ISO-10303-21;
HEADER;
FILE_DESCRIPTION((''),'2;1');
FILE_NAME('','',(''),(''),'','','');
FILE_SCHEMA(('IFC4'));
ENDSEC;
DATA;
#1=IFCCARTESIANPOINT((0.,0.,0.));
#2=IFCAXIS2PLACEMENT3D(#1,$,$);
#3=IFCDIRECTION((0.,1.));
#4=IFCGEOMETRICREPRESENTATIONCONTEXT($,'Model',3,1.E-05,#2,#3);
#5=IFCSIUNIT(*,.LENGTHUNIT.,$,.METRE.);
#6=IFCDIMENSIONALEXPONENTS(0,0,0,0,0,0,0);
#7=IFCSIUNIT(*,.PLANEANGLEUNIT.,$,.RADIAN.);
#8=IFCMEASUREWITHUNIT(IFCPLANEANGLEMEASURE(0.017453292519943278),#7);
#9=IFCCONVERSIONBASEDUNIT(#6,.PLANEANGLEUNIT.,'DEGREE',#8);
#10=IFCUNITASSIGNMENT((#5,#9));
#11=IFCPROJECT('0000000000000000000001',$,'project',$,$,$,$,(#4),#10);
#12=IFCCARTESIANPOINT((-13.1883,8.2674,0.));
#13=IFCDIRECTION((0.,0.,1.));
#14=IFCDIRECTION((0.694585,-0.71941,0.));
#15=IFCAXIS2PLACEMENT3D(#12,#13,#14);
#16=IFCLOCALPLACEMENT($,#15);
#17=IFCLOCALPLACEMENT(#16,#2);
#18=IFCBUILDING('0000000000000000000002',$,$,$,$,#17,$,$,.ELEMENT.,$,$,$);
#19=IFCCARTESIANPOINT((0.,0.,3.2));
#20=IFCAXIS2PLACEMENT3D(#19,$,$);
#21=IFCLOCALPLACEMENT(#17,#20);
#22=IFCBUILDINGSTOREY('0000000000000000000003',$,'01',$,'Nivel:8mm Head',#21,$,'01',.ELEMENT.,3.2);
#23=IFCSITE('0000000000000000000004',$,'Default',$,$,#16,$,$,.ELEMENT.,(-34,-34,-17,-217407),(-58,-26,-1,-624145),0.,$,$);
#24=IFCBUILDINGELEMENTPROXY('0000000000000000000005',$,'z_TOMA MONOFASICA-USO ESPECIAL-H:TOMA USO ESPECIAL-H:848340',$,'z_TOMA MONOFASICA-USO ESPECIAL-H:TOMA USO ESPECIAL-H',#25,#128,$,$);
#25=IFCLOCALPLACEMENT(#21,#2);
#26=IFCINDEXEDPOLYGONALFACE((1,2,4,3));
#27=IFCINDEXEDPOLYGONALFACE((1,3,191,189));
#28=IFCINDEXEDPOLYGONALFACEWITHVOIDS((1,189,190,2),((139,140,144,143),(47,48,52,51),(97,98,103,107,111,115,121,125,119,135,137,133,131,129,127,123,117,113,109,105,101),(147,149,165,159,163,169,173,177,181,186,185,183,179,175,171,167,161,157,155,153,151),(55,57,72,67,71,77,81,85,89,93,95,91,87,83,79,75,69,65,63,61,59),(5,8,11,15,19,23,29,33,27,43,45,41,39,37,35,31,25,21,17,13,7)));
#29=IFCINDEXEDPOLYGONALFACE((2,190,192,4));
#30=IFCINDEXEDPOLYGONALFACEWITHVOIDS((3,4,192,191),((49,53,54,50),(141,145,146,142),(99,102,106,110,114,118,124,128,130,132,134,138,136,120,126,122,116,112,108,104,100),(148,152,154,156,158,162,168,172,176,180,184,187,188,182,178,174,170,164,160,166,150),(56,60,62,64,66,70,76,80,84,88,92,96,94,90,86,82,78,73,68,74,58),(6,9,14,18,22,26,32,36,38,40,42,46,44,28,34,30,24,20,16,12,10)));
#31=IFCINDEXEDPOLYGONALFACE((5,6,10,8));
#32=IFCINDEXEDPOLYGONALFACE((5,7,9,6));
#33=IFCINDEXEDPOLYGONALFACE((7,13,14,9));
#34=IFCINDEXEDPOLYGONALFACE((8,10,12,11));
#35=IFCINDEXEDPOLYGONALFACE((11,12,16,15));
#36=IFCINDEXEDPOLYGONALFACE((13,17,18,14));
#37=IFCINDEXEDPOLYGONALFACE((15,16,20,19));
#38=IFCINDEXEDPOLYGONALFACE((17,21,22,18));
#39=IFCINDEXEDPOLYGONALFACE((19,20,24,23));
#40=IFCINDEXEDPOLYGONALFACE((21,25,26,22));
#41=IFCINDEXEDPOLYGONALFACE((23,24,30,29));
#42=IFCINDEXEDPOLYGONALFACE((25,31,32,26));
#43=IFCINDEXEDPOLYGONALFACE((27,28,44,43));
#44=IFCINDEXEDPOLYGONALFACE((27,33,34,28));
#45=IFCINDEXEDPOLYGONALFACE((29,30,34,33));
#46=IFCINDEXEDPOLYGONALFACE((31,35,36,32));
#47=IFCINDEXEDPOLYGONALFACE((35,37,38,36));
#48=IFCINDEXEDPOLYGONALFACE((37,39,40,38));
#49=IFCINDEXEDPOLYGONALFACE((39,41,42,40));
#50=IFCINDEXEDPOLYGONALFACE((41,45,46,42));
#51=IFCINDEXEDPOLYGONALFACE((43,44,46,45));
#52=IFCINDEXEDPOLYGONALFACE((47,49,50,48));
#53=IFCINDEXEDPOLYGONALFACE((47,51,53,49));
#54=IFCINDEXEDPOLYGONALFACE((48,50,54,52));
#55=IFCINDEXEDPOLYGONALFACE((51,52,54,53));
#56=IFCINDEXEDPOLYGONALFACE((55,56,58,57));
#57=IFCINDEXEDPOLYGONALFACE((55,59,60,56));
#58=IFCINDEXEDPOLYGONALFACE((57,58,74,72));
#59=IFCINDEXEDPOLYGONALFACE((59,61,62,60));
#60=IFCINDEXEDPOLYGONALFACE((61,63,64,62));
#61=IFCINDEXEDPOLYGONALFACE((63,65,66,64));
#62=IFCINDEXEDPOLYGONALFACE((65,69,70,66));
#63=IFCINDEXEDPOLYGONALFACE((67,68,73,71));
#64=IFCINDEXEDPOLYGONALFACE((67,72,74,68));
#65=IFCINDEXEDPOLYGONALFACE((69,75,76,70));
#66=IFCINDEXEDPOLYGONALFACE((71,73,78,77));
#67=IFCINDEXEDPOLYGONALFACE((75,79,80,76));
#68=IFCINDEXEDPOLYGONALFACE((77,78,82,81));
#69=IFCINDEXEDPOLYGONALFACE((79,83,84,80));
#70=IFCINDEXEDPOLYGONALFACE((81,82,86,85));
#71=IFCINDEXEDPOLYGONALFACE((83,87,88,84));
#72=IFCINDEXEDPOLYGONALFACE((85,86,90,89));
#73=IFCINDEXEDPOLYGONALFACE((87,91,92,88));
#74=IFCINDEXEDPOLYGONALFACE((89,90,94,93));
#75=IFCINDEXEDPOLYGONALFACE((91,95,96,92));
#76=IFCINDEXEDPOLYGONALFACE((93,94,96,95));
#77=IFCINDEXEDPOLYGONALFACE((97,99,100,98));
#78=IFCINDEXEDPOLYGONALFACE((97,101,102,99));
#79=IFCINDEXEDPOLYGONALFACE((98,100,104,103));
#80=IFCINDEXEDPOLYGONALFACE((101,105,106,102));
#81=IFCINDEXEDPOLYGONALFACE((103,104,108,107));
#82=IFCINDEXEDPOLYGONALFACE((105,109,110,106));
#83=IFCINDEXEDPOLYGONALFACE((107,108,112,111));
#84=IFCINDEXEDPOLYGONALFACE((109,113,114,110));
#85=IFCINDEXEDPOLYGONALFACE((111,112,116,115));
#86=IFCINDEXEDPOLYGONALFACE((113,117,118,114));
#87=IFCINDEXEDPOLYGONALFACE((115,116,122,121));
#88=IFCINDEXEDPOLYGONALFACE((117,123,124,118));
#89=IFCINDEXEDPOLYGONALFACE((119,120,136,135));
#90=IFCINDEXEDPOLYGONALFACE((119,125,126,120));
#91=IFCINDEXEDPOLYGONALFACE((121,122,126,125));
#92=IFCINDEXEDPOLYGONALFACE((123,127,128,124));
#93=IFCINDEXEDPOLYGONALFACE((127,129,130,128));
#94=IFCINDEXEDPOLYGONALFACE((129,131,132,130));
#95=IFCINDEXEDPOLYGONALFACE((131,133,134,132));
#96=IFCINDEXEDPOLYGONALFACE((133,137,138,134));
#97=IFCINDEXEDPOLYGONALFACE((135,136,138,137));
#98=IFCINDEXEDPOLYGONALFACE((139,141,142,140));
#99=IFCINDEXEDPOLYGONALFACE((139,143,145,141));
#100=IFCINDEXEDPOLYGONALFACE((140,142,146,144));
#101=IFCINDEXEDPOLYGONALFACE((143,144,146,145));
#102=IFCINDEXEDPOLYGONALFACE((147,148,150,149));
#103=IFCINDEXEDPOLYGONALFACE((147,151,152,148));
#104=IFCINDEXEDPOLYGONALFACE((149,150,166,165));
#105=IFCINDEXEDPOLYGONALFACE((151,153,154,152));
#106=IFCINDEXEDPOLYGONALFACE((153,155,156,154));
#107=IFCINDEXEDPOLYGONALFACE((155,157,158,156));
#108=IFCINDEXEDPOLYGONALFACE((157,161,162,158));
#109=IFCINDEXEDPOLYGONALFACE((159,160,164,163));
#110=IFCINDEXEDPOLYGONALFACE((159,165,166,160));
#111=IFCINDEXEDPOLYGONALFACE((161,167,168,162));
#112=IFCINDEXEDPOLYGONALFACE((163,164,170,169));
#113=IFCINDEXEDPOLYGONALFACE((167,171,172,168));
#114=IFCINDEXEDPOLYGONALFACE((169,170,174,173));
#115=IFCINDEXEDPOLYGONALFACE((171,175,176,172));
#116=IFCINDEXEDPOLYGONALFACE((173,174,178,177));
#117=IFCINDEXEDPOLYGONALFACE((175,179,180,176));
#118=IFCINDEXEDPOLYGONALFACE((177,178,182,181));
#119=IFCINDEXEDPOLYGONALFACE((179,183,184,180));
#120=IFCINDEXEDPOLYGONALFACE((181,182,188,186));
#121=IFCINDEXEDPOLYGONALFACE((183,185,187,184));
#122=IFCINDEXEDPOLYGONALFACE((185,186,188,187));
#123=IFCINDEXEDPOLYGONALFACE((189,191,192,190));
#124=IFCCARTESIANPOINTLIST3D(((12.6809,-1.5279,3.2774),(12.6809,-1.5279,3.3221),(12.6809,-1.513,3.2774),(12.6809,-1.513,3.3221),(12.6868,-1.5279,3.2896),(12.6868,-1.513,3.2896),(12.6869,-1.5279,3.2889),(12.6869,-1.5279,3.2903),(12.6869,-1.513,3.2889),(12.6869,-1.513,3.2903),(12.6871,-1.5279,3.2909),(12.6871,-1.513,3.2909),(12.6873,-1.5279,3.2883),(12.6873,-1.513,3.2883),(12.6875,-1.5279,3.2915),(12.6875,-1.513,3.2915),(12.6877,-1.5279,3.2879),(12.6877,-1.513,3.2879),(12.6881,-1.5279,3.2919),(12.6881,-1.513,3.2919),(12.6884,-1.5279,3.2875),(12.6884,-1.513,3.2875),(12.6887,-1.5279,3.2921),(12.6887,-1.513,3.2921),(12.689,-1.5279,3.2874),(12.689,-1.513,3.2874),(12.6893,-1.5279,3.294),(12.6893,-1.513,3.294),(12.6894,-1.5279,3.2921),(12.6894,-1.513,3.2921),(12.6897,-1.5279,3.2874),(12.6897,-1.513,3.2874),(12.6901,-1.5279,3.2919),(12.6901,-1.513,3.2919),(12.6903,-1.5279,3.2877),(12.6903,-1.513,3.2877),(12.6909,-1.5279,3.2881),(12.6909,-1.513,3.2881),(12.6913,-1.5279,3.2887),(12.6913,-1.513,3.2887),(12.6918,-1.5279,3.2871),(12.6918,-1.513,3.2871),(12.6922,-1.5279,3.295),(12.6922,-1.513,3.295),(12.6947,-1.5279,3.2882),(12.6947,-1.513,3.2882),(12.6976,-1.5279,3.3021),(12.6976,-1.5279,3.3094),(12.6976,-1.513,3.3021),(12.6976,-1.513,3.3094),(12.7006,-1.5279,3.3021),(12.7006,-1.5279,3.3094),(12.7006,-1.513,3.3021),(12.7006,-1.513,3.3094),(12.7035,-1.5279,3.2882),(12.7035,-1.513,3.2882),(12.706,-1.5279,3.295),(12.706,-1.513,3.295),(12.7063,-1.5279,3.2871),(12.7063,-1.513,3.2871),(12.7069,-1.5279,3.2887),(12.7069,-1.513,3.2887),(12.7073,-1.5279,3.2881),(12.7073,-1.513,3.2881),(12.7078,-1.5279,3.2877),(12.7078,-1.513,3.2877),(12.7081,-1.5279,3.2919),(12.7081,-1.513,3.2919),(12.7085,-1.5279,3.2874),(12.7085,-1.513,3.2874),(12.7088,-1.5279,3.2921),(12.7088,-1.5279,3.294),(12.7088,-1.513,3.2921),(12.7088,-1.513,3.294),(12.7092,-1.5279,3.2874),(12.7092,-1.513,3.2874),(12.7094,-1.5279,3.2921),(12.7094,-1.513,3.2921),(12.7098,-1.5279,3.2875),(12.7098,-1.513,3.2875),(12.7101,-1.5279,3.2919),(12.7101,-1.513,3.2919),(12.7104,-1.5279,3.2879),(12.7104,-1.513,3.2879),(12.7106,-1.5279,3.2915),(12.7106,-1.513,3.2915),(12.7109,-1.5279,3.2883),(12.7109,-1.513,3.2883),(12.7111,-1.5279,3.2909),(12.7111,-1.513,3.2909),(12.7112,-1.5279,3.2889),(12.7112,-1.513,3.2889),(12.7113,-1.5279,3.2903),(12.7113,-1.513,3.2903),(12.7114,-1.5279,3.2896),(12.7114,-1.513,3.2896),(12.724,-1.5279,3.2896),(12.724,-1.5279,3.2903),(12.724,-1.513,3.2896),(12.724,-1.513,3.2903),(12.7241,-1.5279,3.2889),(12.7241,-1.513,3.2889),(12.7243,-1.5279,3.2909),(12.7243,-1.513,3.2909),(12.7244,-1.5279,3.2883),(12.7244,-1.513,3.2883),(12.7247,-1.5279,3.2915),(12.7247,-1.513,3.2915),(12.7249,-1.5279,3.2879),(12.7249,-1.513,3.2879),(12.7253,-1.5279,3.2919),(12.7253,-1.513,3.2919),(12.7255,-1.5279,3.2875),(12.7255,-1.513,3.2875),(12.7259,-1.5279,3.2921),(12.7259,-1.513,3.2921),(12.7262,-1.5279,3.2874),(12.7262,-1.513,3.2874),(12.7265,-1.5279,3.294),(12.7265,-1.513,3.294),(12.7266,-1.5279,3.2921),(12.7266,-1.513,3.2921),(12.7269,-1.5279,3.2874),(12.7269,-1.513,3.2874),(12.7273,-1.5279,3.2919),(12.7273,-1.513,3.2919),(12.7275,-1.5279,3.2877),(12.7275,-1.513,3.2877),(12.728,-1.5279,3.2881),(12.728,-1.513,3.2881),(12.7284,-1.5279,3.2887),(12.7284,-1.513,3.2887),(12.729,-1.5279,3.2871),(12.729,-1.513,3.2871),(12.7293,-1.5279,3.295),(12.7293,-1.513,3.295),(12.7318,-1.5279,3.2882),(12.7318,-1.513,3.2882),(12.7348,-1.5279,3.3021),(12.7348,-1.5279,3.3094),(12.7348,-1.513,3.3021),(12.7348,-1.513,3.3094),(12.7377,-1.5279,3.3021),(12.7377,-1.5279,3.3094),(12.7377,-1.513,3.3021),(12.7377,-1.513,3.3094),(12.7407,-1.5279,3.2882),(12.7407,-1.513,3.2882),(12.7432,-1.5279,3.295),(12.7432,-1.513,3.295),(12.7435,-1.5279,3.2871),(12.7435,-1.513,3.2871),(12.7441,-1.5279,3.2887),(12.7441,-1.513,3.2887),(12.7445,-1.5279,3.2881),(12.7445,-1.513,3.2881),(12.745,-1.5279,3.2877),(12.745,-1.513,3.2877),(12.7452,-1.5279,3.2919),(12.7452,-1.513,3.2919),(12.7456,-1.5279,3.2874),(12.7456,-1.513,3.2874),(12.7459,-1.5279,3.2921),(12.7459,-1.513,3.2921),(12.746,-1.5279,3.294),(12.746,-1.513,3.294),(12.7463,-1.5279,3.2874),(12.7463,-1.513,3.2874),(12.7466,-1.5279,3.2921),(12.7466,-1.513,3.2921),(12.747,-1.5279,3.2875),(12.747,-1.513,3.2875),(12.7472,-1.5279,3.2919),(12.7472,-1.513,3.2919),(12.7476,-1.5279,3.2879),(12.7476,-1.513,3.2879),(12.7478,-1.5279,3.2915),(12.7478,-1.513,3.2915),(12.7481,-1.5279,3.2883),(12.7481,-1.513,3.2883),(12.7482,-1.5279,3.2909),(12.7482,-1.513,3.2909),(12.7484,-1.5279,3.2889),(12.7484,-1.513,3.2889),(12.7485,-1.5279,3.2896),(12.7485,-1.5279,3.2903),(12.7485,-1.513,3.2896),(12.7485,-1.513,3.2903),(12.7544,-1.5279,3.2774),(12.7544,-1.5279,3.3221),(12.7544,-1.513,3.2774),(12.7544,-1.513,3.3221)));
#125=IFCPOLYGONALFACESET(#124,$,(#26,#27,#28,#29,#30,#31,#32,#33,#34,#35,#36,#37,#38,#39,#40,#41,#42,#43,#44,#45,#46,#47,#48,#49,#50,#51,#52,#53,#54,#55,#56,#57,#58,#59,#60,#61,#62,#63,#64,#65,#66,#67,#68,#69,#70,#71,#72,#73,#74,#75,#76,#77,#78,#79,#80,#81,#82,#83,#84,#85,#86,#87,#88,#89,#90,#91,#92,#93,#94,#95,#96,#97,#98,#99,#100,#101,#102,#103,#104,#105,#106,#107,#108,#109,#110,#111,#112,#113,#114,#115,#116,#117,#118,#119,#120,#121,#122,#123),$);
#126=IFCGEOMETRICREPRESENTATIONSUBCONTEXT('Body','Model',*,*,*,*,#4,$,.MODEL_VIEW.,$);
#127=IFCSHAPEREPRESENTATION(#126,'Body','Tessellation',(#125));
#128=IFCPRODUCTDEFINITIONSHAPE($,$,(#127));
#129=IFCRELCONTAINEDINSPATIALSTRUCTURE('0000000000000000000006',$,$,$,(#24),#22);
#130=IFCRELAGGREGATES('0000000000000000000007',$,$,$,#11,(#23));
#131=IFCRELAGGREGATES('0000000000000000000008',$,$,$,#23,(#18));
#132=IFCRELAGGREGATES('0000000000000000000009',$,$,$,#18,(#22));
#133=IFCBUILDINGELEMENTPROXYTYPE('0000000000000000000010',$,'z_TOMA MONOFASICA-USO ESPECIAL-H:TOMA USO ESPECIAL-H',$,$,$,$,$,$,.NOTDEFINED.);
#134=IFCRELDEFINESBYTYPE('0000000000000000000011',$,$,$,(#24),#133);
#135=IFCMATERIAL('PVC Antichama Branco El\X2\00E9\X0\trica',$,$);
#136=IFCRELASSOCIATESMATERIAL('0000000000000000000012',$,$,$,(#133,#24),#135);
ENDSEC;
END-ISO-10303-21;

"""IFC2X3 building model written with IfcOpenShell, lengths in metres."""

from ifc_helpers import new_model, entity, si_unit, converted_unit, direction, frame, frame_2d, origin, place, context, subcontext, project, spatial, polyline, circle_curve, parameter, trimmed, segment, composite_curve, outline, extrude, source, transform, mapped, material, type_object, type_shapes, element, save


model = new_model("IFC2X3")

# Units and contexts
model_context = context("Model", 3, precision=1e-05, world=origin(), true_north=direction((0.0, 1.0)))
body_context = subcontext(model_context, "Body", "Model", "MODEL_VIEW")
ifc_project = project(units=[si_unit("LENGTHUNIT", "METRE"), converted_unit("PLANEANGLEUNIT", "DEGREE", entity("IfcPlaneAngleMeasure", 0.017453292519943278), si_unit("PLANEANGLEUNIT", "RADIAN"), dimensions=[0, 0, 0, 0, 0, 0, 0])], contexts=[model_context])

# Site, building, storey
site_placement = place(None, frame((-13.1883, 8.2674, 0.0), z_axis=(0.0, 0.0, 1.0), x_axis=(0.694585, -0.71941, 0.0)))
site = spatial("IfcSite", under=ifc_project, at=site_placement, Name="Default", CompositionType="ELEMENT", RefLatitude=(-34, -34, -17, -217407), RefLongitude=(-58, -26, -1, -624145), RefElevation=0.0)
building_placement = place(site_placement, origin())
building = spatial("IfcBuilding", under=site, at=building_placement, CompositionType="ELEMENT")
storey_placement = place(building_placement, frame((0.0, 0.0, 3.2)))
storey = spatial("IfcBuildingStorey", under=building, at=storey_placement, Name="01", ObjectType="Nivel:8mm Head", LongName="01", CompositionType="ELEMENT", Elevation=3.2)

# Building element proxy
ifc_material_1 = material(Name="PVC Antichama Branco Elétrica")
building_element_proxy_type_1 = type_object("IfcBuildingElementProxyType", Name="z_TOMA MONOFASICA-USO ESPECIAL-H:TOMA USO ESPECIAL-H", PredefinedType="NOTDEFINED", material=ifc_material_1)
shared_shape_1 = source(origin(), body_context, "Body", "SweptSolid", [
    extrude(outline(polyline([(-0.0368, -0.0223), (0.0368, -0.0223), (0.0368, 0.0223), (-0.0368, 0.0223), (-0.0368, -0.0223)]), holes=[composite_curve([segment(polyline([(0.0141, 0.0115), (0.0116, 0.0047)]), True, "CONTINUOUS"), segment(polyline([(0.0116, 0.0047), (0.0088, 0.0057)]), True, "CONTINUOUS"), segment(polyline([(0.0088, 0.0057), (0.0096, 0.0078)]), True, "CONTINUOUS"), segment(trimmed(circle_curve(frame_2d((0.0087, 0.0099), x_axis=(1.0, 0.0)), 0.0024), [parameter(27.118901)], [parameter(292.881099)], True, "PARAMETER"), False, "CONTINUOUS"), segment(polyline([(0.0108, 0.011), (0.0113, 0.0126)]), True, "CONTINUOUS"), segment(polyline([(0.0113, 0.0126), (0.0141, 0.0115)]), True, "CONTINUOUS")], self_intersect=False), composite_curve([segment(polyline([(0.0255, 0.0047), (0.023, 0.0115)]), True, "CONTINUOUS"), segment(polyline([(0.023, 0.0115), (0.0258, 0.0126)]), True, "CONTINUOUS"), segment(polyline([(0.0258, 0.0126), (0.0264, 0.011)]), True, "CONTINUOUS"), segment(trimmed(circle_curve(frame_2d((0.0285, 0.0099), x_axis=(1.0, 0.0)), 0.0024), [parameter(247.118901)], [parameter(152.881099)], True, "PARAMETER"), False, "CONTINUOUS"), segment(polyline([(0.0276, 0.0078), (0.0283, 0.0057)]), True, "CONTINUOUS"), segment(polyline([(0.0283, 0.0057), (0.0255, 0.0047)]), True, "CONTINUOUS")], self_intersect=False), polyline([(0.0201, -0.0024), (0.0201, -0.0097), (0.0171, -0.0097), (0.0171, -0.0024), (0.0201, -0.0024)]), composite_curve([segment(polyline([(-0.0141, 0.0115), (-0.0113, 0.0126)]), True, "CONTINUOUS"), segment(polyline([(-0.0113, 0.0126), (-0.0108, 0.011)]), True, "CONTINUOUS"), segment(trimmed(circle_curve(frame_2d((-0.0087, 0.0099), x_axis=(1.0, 0.0)), 0.0024), [parameter(247.118901)], [parameter(152.881099)], True, "PARAMETER"), False, "CONTINUOUS"), segment(polyline([(-0.0096, 0.0078), (-0.0088, 0.0057)]), True, "CONTINUOUS"), segment(polyline([(-0.0088, 0.0057), (-0.0116, 0.0047)]), True, "CONTINUOUS"), segment(polyline([(-0.0116, 0.0047), (-0.0141, 0.0115)]), True, "CONTINUOUS")], self_intersect=False), composite_curve([segment(polyline([(-0.0255, 0.0047), (-0.0283, 0.0057)]), True, "CONTINUOUS"), segment(polyline([(-0.0283, 0.0057), (-0.0276, 0.0078)]), True, "CONTINUOUS"), segment(trimmed(circle_curve(frame_2d((-0.0285, 0.0099), x_axis=(1.0, 0.0)), 0.0024), [parameter(27.118901)], [parameter(292.881099)], True, "PARAMETER"), False, "CONTINUOUS"), segment(polyline([(-0.0264, 0.011), (-0.0258, 0.0126)]), True, "CONTINUOUS"), segment(polyline([(-0.0258, 0.0126), (-0.023, 0.0115)]), True, "CONTINUOUS"), segment(polyline([(-0.023, 0.0115), (-0.0255, 0.0047)]), True, "CONTINUOUS")], self_intersect=False), polyline([(-0.0201, -0.0024), (-0.0171, -0.0024), (-0.0171, -0.0097), (-0.0201, -0.0097), (-0.0201, -0.0024)])]), frame((0.0, -0.005, 0.0223), z_axis=(0.0, 1.0, 0.0), x_axis=(1.0, 0.0, 0.0)), (0.0, 0.0, 1.0), 0.0148),
])
type_shapes(building_element_proxy_type_1, [shared_shape_1])
for number, where, name in (
    (1, (12.7177, -1.5229, 3.2774), "z_TOMA MONOFASICA-USO ESPECIAL-H:TOMA USO ESPECIAL-H:848340"),
):
    element("IfcBuildingElementProxy", number, at=place(storey_placement, frame(where)), inside=storey, type_object=building_element_proxy_type_1, material=ifc_material_1, Name=name, ObjectType="z_TOMA MONOFASICA-USO ESPECIAL-H:TOMA USO ESPECIAL-H", context=body_context, shape_type="MappedRepresentation", body=[
        mapped(shared_shape_1, transform((0.0, 0.0, 0.0), scale=1.0)),
    ])

save(model, "model.ifc")
